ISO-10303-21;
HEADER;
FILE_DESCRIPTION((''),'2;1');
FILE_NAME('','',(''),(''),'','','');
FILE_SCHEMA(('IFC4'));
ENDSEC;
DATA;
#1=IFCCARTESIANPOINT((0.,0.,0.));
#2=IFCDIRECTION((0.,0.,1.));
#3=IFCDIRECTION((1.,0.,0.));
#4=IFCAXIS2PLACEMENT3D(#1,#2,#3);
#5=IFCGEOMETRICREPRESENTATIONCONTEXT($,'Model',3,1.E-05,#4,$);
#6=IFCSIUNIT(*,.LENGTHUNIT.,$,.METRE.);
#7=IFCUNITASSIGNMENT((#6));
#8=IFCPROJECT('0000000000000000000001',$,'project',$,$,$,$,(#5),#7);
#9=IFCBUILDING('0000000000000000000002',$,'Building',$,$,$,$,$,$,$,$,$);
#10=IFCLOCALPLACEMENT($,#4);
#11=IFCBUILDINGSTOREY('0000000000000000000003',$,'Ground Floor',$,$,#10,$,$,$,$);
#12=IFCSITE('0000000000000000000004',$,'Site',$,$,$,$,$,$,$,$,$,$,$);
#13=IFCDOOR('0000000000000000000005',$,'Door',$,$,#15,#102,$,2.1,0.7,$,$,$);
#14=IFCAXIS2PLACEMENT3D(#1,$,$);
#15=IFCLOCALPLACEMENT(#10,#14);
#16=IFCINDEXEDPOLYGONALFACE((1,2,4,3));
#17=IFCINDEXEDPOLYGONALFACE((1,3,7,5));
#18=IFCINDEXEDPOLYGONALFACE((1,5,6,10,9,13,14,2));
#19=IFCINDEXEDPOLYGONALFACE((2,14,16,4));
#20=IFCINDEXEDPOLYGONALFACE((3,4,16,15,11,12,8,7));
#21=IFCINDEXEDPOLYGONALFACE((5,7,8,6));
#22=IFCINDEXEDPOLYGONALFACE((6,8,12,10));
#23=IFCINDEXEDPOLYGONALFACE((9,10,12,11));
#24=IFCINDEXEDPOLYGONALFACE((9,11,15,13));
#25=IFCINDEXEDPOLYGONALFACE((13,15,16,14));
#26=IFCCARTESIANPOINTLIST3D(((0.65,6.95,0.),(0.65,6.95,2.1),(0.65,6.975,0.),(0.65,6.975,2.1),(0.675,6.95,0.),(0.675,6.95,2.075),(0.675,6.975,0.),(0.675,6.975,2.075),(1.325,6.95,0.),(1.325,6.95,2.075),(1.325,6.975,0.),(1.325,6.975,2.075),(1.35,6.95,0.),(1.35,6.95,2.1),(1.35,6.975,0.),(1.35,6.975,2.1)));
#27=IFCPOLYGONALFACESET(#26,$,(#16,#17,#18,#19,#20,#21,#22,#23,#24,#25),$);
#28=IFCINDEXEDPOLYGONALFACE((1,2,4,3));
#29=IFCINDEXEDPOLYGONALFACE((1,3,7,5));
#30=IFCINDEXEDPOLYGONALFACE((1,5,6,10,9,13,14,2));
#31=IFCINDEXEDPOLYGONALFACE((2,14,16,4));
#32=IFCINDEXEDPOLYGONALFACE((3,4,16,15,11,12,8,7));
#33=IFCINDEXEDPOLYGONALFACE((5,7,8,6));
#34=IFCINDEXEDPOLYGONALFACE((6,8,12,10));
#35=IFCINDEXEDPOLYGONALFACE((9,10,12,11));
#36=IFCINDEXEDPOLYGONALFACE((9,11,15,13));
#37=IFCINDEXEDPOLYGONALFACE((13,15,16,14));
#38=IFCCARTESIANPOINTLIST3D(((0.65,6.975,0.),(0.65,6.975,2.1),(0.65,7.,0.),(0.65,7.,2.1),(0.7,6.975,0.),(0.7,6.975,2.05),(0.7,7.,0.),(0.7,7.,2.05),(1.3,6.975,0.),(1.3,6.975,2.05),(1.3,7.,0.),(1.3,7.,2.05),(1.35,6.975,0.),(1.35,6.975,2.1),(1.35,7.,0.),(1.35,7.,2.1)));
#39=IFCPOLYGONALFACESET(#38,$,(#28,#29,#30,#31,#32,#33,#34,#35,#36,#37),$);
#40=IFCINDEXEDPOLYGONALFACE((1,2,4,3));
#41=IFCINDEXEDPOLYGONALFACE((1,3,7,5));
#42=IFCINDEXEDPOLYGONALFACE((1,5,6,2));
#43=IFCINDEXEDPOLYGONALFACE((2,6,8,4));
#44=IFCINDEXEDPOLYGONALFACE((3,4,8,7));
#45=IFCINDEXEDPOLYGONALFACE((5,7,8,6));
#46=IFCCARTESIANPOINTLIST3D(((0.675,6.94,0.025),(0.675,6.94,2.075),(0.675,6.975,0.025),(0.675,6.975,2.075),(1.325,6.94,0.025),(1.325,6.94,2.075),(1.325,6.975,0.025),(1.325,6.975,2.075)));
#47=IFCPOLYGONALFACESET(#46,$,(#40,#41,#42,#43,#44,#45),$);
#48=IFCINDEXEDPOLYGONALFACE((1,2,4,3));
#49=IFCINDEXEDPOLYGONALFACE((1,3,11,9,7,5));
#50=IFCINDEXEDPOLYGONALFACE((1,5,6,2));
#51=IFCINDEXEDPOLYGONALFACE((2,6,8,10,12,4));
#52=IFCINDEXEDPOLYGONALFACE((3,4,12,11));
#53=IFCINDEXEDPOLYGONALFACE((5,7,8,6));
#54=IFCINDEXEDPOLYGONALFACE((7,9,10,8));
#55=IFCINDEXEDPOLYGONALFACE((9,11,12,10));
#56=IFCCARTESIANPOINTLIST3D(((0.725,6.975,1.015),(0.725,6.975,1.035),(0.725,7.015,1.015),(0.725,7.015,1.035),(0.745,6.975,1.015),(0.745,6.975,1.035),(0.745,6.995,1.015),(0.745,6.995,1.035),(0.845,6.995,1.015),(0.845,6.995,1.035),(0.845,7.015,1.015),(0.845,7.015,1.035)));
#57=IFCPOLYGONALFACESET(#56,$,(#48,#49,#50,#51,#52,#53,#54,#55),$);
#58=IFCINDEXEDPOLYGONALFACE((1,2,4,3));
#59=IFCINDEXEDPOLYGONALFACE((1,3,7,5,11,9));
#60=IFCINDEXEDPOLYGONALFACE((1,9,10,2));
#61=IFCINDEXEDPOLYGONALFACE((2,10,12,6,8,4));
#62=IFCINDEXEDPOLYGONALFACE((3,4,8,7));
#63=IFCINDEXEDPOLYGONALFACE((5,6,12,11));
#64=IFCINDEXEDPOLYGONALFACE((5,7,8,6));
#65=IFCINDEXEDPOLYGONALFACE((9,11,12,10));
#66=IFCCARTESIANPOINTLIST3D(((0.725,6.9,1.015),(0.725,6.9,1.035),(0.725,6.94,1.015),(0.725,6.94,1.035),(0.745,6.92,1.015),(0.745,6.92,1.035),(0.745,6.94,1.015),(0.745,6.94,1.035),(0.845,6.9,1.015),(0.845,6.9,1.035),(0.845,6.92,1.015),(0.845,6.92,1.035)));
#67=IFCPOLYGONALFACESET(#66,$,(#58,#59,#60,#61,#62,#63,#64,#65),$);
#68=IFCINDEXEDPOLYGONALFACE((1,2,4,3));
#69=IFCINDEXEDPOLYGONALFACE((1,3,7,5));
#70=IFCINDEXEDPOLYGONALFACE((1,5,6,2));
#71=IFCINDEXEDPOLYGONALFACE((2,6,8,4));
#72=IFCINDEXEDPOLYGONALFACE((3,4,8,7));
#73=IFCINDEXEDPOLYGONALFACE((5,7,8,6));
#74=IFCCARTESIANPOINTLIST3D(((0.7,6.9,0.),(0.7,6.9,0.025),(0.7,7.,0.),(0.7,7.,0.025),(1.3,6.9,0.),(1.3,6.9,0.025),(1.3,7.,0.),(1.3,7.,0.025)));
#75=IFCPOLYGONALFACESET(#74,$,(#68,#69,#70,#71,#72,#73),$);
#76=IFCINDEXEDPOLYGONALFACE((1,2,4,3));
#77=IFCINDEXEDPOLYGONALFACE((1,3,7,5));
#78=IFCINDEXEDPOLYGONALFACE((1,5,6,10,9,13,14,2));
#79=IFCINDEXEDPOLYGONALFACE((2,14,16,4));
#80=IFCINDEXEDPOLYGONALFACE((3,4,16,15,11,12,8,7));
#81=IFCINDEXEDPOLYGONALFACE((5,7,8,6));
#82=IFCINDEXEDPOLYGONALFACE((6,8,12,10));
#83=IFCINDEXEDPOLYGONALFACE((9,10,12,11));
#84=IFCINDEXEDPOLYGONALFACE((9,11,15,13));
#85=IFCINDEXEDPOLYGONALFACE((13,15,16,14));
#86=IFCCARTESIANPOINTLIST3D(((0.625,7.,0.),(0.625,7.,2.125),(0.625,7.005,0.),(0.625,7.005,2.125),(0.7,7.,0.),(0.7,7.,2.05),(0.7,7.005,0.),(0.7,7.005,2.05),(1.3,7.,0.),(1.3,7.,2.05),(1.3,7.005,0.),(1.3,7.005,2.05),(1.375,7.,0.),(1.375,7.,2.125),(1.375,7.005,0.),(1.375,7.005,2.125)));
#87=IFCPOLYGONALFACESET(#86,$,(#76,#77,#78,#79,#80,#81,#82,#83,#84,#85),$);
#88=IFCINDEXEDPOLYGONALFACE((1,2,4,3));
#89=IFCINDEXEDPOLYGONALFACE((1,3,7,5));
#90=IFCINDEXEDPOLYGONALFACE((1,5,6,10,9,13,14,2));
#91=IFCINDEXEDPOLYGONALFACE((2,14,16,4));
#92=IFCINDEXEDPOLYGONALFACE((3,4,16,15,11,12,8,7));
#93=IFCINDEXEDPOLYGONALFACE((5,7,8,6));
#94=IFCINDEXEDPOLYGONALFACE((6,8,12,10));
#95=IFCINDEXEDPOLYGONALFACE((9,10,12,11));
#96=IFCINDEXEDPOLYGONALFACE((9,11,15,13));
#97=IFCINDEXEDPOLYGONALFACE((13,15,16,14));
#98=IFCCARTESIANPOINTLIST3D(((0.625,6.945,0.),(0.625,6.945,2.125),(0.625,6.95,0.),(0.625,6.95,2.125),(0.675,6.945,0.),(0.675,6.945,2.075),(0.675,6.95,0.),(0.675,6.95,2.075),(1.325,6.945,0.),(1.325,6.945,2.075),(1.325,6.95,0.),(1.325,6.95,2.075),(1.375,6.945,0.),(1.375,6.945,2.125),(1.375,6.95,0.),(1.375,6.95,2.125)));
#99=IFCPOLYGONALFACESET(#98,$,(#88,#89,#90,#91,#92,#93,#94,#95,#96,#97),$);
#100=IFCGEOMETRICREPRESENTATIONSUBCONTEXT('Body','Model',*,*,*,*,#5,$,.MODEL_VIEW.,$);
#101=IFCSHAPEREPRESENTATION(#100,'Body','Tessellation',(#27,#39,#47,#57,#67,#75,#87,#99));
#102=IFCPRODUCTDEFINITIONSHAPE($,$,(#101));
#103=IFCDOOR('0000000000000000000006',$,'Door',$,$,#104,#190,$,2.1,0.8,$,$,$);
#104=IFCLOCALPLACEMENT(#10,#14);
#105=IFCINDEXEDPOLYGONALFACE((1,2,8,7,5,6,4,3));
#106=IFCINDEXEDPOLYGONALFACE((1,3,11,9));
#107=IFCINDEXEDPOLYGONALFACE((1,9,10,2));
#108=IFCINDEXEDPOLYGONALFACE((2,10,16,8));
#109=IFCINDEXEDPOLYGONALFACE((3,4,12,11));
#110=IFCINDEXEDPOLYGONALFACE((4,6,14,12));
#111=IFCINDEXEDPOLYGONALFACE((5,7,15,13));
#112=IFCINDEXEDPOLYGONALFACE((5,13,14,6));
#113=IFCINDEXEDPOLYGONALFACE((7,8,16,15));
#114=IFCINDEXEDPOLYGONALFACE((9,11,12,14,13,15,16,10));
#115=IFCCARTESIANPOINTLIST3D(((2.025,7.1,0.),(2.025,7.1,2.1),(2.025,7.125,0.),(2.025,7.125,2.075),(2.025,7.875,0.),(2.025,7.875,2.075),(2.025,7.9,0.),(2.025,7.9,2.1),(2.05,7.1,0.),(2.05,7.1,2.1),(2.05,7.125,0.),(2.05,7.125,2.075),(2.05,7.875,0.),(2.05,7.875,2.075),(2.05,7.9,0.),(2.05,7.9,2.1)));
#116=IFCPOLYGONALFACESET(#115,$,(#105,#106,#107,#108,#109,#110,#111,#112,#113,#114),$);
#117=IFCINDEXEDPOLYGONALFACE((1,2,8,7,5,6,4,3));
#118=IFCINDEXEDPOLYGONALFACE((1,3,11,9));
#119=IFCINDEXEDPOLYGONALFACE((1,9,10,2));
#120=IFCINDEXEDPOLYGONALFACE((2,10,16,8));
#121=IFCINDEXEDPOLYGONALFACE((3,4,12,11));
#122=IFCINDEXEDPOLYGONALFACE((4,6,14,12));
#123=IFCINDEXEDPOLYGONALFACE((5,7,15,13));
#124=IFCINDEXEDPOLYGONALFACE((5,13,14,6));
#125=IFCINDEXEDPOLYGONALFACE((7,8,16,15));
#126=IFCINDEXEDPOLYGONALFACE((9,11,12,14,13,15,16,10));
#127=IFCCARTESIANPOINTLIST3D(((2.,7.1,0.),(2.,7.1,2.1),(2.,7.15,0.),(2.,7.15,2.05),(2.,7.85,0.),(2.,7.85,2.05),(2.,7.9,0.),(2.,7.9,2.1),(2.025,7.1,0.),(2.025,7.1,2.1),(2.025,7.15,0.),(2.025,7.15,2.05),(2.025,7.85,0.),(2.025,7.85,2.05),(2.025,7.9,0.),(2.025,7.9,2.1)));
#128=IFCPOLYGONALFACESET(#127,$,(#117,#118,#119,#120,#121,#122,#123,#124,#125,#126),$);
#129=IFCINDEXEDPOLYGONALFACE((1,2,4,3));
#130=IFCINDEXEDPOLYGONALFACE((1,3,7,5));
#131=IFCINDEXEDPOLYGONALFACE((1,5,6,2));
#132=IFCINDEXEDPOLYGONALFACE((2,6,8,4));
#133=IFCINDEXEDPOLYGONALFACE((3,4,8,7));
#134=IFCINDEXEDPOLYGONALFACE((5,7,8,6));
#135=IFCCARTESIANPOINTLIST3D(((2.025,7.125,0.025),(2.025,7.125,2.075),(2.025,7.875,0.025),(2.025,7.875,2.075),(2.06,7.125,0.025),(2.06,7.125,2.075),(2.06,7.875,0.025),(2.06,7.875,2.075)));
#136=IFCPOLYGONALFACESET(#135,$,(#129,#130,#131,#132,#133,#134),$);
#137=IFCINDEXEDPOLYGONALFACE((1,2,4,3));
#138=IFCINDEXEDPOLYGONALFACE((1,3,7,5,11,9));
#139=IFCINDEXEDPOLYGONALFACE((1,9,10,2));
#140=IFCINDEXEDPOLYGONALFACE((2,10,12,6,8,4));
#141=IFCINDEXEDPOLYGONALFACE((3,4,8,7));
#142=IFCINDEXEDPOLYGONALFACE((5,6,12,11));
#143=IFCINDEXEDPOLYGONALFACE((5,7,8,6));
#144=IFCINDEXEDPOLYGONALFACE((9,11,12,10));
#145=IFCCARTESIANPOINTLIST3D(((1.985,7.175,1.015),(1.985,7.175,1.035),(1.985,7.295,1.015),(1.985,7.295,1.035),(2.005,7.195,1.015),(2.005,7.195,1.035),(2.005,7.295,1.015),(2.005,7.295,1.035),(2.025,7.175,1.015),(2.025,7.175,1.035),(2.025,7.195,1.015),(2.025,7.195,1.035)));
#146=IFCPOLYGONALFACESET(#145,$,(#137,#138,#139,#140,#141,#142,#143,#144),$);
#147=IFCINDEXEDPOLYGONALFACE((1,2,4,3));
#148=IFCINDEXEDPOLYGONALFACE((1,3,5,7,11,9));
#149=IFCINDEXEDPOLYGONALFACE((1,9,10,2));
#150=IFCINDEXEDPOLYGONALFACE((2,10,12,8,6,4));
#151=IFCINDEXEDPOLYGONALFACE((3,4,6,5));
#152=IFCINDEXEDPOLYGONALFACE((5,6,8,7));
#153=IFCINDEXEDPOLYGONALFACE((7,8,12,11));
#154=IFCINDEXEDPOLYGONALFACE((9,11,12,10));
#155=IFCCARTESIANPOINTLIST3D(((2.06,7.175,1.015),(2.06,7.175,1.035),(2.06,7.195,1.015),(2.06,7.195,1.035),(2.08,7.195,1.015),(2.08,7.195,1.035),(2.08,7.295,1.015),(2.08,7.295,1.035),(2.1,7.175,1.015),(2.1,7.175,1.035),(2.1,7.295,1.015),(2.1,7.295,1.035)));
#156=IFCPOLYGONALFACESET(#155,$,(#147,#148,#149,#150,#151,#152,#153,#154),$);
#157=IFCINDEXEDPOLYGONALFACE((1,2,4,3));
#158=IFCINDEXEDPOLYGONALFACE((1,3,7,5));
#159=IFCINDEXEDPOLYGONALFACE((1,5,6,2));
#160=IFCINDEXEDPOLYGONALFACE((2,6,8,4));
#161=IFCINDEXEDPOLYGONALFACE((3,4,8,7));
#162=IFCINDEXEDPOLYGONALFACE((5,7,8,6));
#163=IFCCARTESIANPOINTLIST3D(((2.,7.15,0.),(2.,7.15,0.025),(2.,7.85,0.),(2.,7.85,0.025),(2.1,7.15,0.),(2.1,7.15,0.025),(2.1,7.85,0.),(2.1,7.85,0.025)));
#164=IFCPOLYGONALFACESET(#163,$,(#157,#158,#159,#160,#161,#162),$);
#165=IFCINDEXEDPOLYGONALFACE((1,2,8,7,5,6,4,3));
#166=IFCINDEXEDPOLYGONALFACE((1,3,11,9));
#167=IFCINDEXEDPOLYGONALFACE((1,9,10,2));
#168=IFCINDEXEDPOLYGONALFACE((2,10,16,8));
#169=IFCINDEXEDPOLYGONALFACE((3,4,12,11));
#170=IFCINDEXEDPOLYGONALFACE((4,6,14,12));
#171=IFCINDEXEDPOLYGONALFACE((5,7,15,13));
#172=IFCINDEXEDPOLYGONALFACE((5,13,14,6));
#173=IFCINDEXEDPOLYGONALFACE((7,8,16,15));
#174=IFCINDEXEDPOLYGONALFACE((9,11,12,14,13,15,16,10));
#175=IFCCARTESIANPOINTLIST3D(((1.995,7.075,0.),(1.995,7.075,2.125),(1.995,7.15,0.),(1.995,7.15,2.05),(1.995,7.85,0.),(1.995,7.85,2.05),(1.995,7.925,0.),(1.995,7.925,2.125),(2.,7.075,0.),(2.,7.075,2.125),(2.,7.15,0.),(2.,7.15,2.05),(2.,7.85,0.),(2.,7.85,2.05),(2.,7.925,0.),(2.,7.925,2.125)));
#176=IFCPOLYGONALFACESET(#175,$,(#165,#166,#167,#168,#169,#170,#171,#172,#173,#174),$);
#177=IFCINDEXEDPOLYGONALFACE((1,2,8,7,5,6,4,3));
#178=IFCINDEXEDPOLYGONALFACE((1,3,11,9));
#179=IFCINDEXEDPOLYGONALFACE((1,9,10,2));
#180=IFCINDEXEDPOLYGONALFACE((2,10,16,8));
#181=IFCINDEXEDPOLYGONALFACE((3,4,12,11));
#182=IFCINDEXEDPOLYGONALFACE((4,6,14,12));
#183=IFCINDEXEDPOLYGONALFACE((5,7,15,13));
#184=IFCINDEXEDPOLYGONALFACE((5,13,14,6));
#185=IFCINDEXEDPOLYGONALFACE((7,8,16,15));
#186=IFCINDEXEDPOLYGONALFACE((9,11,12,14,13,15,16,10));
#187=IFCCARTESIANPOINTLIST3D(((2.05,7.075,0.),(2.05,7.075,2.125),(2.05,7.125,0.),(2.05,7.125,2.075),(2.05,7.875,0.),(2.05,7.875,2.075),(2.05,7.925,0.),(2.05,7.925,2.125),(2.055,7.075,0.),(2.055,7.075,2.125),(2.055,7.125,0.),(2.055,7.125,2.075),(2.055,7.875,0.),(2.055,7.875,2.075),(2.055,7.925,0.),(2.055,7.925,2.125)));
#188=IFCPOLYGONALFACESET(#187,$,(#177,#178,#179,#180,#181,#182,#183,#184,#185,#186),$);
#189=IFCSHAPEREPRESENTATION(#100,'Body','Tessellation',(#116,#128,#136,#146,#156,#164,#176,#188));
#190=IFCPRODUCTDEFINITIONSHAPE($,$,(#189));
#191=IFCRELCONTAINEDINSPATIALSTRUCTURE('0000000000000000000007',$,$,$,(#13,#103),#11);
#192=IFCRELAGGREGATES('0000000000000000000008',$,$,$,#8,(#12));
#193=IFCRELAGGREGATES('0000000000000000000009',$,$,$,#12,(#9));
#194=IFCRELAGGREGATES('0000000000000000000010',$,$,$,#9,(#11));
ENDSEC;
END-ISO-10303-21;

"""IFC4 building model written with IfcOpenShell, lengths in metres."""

from ifc_helpers import new_model, si_unit, frame, origin_with_axes, place, context, subcontext, project, spatial, line, indexed_curve, outline, extrude, element, save


model = new_model("IFC4")

# Units and contexts
model_context = context("Model", 3, precision=1e-05, world=origin_with_axes())
body_context = subcontext(model_context, "Body", "Model", "MODEL_VIEW")
ifc_project = project(units=[si_unit("LENGTHUNIT", "METRE")], contexts=[model_context])

# Site, building, storey
site = spatial("IfcSite", under=ifc_project, Name="Site")
building = spatial("IfcBuilding", under=site, Name="Building")
storey_placement = place(None, origin_with_axes())
storey = spatial("IfcBuildingStorey", under=building, at=storey_placement, Name="Ground Floor")

# Doors
door_1_placement = place(storey_placement, frame((1.35, 7.0, 0.0), z_axis=(0.0, 0.0, 1.0), x_axis=(-1.0, 0.0, 0.0)))
element("IfcDoor", 1, at=door_1_placement, inside=storey, Name="Door", OverallHeight=2.1, OverallWidth=0.7, context=body_context, shape_type="SweptSolid", body=[
    extrude(outline(indexed_curve([(0.0, 0.0), (0.0, 2.1), (0.7, 2.1), (0.7, 0.0), (0.675, 0.0), (0.675, 2.075), (0.025, 2.075), (0.025, 0.0)], segments=[line(1, 2, 3, 4, 5, 6, 7, 8, 1)])), frame((0.0, 0.025, 0.0), z_axis=(0.0, -1.0, 0.0), x_axis=(1.0, 0.0, 0.0)), (0.0, 0.0, -1.0), 0.025),
    extrude(outline(indexed_curve([(0.0, 0.0), (0.0, 2.1), (0.7, 2.1), (0.7, 0.0), (0.65, 0.0), (0.65, 2.05), (0.05, 2.05), (0.05, 0.0)], segments=[line(1, 2, 3, 4, 5, 6, 7, 8, 1)])), frame((0.0, 0.0, 0.0), z_axis=(0.0, -1.0, 0.0), x_axis=(1.0, 0.0, 0.0)), (0.0, 0.0, -1.0), 0.025),
    extrude(outline(indexed_curve([(0.0, 0.0), (0.65, 0.0), (0.65, 0.035), (0.0, 0.035)], segments=[line(1, 2, 3, 4, 1)])), frame((0.025, 0.025, 0.025), z_axis=(0.0, 0.0, 1.0), x_axis=(1.0, 0.0, 0.0)), (0.0, 0.0, 1.0), 2.05),
    extrude(outline(indexed_curve([(0.0, 0.0), (0.0, -0.04), (-0.12, -0.04), (-0.12, -0.02), (-0.02, -0.02), (-0.02, 0.0)], segments=[line(1, 2, 3, 4, 5, 6, 1)])), frame((0.625, 0.025, 1.015), z_axis=(0.0, 0.0, 1.0), x_axis=(1.0, 0.0, 0.0)), (0.0, 0.0, 1.0), 0.02),
    extrude(outline(indexed_curve([(0.0, 0.0), (0.0, 0.04), (-0.12, 0.04), (-0.12, 0.02), (-0.02, 0.02), (-0.02, 0.0)], segments=[line(1, 2, 3, 4, 5, 6, 1)])), frame((0.625, 0.06, 1.015), z_axis=(0.0, 0.0, 1.0), x_axis=(1.0, 0.0, 0.0)), (0.0, 0.0, 1.0), 0.02),
    extrude(outline(indexed_curve([(0.0, 0.0), (0.6, 0.0), (0.6, 0.1), (0.0, 0.1)], segments=[line(1, 2, 3, 4, 1)])), frame((0.05, 0.0, 0.0), z_axis=(0.0, 0.0, 1.0), x_axis=(1.0, 0.0, 0.0)), (0.0, 0.0, 1.0), 0.025),
    extrude(outline(indexed_curve([(0.0, 0.0), (0.0, 2.125), (0.75, 2.125), (0.75, 0.0), (0.675, 0.0), (0.675, 2.05), (0.075, 2.05), (0.075, 0.0)], segments=[line(1, 2, 3, 4, 5, 6, 7, 8, 1)])), frame((-0.025, -0.005, 0.0), z_axis=(0.0, -1.0, 0.0), x_axis=(1.0, 0.0, 0.0)), (0.0, 0.0, -1.0), 0.005),
    extrude(outline(indexed_curve([(0.0, 0.0), (0.0, 2.125), (0.75, 2.125), (0.75, 0.0), (0.7, 0.0), (0.7, 2.075), (0.05, 2.075), (0.05, 0.0)], segments=[line(1, 2, 3, 4, 5, 6, 7, 8, 1)])), frame((-0.025, 0.05, 0.0), z_axis=(0.0, -1.0, 0.0), x_axis=(1.0, 0.0, 0.0)), (0.0, 0.0, -1.0), 0.005),
])
door_2_placement = place(storey_placement, frame((2.0, 7.9, 0.0), z_axis=(0.0, 0.0, 1.0), x_axis=(0.0, -1.0, 0.0)))
element("IfcDoor", 2, at=door_2_placement, inside=storey, Name="Door", OverallHeight=2.1, OverallWidth=0.8, context=body_context, shape_type="SweptSolid", body=[
    extrude(outline(indexed_curve([(0.0, 0.0), (0.0, 2.1), (0.8, 2.1), (0.8, 0.0), (0.775, 0.0), (0.775, 2.075), (0.025, 2.075), (0.025, 0.0)], segments=[line(1, 2, 3, 4, 5, 6, 7, 8, 1)])), frame((0.0, 0.025, 0.0), z_axis=(0.0, -1.0, 0.0), x_axis=(1.0, 0.0, 0.0)), (0.0, 0.0, -1.0), 0.025),
    extrude(outline(indexed_curve([(0.0, 0.0), (0.0, 2.1), (0.8, 2.1), (0.8, 0.0), (0.75, 0.0), (0.75, 2.05), (0.05, 2.05), (0.05, 0.0)], segments=[line(1, 2, 3, 4, 5, 6, 7, 8, 1)])), frame((0.0, 0.0, 0.0), z_axis=(0.0, -1.0, 0.0), x_axis=(1.0, 0.0, 0.0)), (0.0, 0.0, -1.0), 0.025),
    extrude(outline(indexed_curve([(0.0, 0.0), (0.75, 0.0), (0.75, 0.035), (0.0, 0.035)], segments=[line(1, 2, 3, 4, 1)])), frame((0.025, 0.025, 0.025), z_axis=(0.0, 0.0, 1.0), x_axis=(1.0, 0.0, 0.0)), (0.0, 0.0, 1.0), 2.05),
    extrude(outline(indexed_curve([(0.0, 0.0), (0.0, -0.04), (-0.12, -0.04), (-0.12, -0.02), (-0.02, -0.02), (-0.02, 0.0)], segments=[line(1, 2, 3, 4, 5, 6, 1)])), frame((0.725, 0.025, 1.015), z_axis=(0.0, 0.0, 1.0), x_axis=(1.0, 0.0, 0.0)), (0.0, 0.0, 1.0), 0.02),
    extrude(outline(indexed_curve([(0.0, 0.0), (0.0, 0.04), (-0.12, 0.04), (-0.12, 0.02), (-0.02, 0.02), (-0.02, 0.0)], segments=[line(1, 2, 3, 4, 5, 6, 1)])), frame((0.725, 0.06, 1.015), z_axis=(0.0, 0.0, 1.0), x_axis=(1.0, 0.0, 0.0)), (0.0, 0.0, 1.0), 0.02),
    extrude(outline(indexed_curve([(0.0, 0.0), (0.7, 0.0), (0.7, 0.1), (0.0, 0.1)], segments=[line(1, 2, 3, 4, 1)])), frame((0.05, 0.0, 0.0), z_axis=(0.0, 0.0, 1.0), x_axis=(1.0, 0.0, 0.0)), (0.0, 0.0, 1.0), 0.025),
    extrude(outline(indexed_curve([(0.0, 0.0), (0.0, 2.125), (0.85, 2.125), (0.85, 0.0), (0.775, 0.0), (0.775, 2.05), (0.075, 2.05), (0.075, 0.0)], segments=[line(1, 2, 3, 4, 5, 6, 7, 8, 1)])), frame((-0.025, -0.005, 0.0), z_axis=(0.0, -1.0, 0.0), x_axis=(1.0, 0.0, 0.0)), (0.0, 0.0, -1.0), 0.005),
    extrude(outline(indexed_curve([(0.0, 0.0), (0.0, 2.125), (0.85, 2.125), (0.85, 0.0), (0.8, 0.0), (0.8, 2.075), (0.05, 2.075), (0.05, 0.0)], segments=[line(1, 2, 3, 4, 5, 6, 7, 8, 1)])), frame((-0.025, 0.05, 0.0), z_axis=(0.0, -1.0, 0.0), x_axis=(1.0, 0.0, 0.0)), (0.0, 0.0, -1.0), 0.005),
])

save(model, "model.ifc")
